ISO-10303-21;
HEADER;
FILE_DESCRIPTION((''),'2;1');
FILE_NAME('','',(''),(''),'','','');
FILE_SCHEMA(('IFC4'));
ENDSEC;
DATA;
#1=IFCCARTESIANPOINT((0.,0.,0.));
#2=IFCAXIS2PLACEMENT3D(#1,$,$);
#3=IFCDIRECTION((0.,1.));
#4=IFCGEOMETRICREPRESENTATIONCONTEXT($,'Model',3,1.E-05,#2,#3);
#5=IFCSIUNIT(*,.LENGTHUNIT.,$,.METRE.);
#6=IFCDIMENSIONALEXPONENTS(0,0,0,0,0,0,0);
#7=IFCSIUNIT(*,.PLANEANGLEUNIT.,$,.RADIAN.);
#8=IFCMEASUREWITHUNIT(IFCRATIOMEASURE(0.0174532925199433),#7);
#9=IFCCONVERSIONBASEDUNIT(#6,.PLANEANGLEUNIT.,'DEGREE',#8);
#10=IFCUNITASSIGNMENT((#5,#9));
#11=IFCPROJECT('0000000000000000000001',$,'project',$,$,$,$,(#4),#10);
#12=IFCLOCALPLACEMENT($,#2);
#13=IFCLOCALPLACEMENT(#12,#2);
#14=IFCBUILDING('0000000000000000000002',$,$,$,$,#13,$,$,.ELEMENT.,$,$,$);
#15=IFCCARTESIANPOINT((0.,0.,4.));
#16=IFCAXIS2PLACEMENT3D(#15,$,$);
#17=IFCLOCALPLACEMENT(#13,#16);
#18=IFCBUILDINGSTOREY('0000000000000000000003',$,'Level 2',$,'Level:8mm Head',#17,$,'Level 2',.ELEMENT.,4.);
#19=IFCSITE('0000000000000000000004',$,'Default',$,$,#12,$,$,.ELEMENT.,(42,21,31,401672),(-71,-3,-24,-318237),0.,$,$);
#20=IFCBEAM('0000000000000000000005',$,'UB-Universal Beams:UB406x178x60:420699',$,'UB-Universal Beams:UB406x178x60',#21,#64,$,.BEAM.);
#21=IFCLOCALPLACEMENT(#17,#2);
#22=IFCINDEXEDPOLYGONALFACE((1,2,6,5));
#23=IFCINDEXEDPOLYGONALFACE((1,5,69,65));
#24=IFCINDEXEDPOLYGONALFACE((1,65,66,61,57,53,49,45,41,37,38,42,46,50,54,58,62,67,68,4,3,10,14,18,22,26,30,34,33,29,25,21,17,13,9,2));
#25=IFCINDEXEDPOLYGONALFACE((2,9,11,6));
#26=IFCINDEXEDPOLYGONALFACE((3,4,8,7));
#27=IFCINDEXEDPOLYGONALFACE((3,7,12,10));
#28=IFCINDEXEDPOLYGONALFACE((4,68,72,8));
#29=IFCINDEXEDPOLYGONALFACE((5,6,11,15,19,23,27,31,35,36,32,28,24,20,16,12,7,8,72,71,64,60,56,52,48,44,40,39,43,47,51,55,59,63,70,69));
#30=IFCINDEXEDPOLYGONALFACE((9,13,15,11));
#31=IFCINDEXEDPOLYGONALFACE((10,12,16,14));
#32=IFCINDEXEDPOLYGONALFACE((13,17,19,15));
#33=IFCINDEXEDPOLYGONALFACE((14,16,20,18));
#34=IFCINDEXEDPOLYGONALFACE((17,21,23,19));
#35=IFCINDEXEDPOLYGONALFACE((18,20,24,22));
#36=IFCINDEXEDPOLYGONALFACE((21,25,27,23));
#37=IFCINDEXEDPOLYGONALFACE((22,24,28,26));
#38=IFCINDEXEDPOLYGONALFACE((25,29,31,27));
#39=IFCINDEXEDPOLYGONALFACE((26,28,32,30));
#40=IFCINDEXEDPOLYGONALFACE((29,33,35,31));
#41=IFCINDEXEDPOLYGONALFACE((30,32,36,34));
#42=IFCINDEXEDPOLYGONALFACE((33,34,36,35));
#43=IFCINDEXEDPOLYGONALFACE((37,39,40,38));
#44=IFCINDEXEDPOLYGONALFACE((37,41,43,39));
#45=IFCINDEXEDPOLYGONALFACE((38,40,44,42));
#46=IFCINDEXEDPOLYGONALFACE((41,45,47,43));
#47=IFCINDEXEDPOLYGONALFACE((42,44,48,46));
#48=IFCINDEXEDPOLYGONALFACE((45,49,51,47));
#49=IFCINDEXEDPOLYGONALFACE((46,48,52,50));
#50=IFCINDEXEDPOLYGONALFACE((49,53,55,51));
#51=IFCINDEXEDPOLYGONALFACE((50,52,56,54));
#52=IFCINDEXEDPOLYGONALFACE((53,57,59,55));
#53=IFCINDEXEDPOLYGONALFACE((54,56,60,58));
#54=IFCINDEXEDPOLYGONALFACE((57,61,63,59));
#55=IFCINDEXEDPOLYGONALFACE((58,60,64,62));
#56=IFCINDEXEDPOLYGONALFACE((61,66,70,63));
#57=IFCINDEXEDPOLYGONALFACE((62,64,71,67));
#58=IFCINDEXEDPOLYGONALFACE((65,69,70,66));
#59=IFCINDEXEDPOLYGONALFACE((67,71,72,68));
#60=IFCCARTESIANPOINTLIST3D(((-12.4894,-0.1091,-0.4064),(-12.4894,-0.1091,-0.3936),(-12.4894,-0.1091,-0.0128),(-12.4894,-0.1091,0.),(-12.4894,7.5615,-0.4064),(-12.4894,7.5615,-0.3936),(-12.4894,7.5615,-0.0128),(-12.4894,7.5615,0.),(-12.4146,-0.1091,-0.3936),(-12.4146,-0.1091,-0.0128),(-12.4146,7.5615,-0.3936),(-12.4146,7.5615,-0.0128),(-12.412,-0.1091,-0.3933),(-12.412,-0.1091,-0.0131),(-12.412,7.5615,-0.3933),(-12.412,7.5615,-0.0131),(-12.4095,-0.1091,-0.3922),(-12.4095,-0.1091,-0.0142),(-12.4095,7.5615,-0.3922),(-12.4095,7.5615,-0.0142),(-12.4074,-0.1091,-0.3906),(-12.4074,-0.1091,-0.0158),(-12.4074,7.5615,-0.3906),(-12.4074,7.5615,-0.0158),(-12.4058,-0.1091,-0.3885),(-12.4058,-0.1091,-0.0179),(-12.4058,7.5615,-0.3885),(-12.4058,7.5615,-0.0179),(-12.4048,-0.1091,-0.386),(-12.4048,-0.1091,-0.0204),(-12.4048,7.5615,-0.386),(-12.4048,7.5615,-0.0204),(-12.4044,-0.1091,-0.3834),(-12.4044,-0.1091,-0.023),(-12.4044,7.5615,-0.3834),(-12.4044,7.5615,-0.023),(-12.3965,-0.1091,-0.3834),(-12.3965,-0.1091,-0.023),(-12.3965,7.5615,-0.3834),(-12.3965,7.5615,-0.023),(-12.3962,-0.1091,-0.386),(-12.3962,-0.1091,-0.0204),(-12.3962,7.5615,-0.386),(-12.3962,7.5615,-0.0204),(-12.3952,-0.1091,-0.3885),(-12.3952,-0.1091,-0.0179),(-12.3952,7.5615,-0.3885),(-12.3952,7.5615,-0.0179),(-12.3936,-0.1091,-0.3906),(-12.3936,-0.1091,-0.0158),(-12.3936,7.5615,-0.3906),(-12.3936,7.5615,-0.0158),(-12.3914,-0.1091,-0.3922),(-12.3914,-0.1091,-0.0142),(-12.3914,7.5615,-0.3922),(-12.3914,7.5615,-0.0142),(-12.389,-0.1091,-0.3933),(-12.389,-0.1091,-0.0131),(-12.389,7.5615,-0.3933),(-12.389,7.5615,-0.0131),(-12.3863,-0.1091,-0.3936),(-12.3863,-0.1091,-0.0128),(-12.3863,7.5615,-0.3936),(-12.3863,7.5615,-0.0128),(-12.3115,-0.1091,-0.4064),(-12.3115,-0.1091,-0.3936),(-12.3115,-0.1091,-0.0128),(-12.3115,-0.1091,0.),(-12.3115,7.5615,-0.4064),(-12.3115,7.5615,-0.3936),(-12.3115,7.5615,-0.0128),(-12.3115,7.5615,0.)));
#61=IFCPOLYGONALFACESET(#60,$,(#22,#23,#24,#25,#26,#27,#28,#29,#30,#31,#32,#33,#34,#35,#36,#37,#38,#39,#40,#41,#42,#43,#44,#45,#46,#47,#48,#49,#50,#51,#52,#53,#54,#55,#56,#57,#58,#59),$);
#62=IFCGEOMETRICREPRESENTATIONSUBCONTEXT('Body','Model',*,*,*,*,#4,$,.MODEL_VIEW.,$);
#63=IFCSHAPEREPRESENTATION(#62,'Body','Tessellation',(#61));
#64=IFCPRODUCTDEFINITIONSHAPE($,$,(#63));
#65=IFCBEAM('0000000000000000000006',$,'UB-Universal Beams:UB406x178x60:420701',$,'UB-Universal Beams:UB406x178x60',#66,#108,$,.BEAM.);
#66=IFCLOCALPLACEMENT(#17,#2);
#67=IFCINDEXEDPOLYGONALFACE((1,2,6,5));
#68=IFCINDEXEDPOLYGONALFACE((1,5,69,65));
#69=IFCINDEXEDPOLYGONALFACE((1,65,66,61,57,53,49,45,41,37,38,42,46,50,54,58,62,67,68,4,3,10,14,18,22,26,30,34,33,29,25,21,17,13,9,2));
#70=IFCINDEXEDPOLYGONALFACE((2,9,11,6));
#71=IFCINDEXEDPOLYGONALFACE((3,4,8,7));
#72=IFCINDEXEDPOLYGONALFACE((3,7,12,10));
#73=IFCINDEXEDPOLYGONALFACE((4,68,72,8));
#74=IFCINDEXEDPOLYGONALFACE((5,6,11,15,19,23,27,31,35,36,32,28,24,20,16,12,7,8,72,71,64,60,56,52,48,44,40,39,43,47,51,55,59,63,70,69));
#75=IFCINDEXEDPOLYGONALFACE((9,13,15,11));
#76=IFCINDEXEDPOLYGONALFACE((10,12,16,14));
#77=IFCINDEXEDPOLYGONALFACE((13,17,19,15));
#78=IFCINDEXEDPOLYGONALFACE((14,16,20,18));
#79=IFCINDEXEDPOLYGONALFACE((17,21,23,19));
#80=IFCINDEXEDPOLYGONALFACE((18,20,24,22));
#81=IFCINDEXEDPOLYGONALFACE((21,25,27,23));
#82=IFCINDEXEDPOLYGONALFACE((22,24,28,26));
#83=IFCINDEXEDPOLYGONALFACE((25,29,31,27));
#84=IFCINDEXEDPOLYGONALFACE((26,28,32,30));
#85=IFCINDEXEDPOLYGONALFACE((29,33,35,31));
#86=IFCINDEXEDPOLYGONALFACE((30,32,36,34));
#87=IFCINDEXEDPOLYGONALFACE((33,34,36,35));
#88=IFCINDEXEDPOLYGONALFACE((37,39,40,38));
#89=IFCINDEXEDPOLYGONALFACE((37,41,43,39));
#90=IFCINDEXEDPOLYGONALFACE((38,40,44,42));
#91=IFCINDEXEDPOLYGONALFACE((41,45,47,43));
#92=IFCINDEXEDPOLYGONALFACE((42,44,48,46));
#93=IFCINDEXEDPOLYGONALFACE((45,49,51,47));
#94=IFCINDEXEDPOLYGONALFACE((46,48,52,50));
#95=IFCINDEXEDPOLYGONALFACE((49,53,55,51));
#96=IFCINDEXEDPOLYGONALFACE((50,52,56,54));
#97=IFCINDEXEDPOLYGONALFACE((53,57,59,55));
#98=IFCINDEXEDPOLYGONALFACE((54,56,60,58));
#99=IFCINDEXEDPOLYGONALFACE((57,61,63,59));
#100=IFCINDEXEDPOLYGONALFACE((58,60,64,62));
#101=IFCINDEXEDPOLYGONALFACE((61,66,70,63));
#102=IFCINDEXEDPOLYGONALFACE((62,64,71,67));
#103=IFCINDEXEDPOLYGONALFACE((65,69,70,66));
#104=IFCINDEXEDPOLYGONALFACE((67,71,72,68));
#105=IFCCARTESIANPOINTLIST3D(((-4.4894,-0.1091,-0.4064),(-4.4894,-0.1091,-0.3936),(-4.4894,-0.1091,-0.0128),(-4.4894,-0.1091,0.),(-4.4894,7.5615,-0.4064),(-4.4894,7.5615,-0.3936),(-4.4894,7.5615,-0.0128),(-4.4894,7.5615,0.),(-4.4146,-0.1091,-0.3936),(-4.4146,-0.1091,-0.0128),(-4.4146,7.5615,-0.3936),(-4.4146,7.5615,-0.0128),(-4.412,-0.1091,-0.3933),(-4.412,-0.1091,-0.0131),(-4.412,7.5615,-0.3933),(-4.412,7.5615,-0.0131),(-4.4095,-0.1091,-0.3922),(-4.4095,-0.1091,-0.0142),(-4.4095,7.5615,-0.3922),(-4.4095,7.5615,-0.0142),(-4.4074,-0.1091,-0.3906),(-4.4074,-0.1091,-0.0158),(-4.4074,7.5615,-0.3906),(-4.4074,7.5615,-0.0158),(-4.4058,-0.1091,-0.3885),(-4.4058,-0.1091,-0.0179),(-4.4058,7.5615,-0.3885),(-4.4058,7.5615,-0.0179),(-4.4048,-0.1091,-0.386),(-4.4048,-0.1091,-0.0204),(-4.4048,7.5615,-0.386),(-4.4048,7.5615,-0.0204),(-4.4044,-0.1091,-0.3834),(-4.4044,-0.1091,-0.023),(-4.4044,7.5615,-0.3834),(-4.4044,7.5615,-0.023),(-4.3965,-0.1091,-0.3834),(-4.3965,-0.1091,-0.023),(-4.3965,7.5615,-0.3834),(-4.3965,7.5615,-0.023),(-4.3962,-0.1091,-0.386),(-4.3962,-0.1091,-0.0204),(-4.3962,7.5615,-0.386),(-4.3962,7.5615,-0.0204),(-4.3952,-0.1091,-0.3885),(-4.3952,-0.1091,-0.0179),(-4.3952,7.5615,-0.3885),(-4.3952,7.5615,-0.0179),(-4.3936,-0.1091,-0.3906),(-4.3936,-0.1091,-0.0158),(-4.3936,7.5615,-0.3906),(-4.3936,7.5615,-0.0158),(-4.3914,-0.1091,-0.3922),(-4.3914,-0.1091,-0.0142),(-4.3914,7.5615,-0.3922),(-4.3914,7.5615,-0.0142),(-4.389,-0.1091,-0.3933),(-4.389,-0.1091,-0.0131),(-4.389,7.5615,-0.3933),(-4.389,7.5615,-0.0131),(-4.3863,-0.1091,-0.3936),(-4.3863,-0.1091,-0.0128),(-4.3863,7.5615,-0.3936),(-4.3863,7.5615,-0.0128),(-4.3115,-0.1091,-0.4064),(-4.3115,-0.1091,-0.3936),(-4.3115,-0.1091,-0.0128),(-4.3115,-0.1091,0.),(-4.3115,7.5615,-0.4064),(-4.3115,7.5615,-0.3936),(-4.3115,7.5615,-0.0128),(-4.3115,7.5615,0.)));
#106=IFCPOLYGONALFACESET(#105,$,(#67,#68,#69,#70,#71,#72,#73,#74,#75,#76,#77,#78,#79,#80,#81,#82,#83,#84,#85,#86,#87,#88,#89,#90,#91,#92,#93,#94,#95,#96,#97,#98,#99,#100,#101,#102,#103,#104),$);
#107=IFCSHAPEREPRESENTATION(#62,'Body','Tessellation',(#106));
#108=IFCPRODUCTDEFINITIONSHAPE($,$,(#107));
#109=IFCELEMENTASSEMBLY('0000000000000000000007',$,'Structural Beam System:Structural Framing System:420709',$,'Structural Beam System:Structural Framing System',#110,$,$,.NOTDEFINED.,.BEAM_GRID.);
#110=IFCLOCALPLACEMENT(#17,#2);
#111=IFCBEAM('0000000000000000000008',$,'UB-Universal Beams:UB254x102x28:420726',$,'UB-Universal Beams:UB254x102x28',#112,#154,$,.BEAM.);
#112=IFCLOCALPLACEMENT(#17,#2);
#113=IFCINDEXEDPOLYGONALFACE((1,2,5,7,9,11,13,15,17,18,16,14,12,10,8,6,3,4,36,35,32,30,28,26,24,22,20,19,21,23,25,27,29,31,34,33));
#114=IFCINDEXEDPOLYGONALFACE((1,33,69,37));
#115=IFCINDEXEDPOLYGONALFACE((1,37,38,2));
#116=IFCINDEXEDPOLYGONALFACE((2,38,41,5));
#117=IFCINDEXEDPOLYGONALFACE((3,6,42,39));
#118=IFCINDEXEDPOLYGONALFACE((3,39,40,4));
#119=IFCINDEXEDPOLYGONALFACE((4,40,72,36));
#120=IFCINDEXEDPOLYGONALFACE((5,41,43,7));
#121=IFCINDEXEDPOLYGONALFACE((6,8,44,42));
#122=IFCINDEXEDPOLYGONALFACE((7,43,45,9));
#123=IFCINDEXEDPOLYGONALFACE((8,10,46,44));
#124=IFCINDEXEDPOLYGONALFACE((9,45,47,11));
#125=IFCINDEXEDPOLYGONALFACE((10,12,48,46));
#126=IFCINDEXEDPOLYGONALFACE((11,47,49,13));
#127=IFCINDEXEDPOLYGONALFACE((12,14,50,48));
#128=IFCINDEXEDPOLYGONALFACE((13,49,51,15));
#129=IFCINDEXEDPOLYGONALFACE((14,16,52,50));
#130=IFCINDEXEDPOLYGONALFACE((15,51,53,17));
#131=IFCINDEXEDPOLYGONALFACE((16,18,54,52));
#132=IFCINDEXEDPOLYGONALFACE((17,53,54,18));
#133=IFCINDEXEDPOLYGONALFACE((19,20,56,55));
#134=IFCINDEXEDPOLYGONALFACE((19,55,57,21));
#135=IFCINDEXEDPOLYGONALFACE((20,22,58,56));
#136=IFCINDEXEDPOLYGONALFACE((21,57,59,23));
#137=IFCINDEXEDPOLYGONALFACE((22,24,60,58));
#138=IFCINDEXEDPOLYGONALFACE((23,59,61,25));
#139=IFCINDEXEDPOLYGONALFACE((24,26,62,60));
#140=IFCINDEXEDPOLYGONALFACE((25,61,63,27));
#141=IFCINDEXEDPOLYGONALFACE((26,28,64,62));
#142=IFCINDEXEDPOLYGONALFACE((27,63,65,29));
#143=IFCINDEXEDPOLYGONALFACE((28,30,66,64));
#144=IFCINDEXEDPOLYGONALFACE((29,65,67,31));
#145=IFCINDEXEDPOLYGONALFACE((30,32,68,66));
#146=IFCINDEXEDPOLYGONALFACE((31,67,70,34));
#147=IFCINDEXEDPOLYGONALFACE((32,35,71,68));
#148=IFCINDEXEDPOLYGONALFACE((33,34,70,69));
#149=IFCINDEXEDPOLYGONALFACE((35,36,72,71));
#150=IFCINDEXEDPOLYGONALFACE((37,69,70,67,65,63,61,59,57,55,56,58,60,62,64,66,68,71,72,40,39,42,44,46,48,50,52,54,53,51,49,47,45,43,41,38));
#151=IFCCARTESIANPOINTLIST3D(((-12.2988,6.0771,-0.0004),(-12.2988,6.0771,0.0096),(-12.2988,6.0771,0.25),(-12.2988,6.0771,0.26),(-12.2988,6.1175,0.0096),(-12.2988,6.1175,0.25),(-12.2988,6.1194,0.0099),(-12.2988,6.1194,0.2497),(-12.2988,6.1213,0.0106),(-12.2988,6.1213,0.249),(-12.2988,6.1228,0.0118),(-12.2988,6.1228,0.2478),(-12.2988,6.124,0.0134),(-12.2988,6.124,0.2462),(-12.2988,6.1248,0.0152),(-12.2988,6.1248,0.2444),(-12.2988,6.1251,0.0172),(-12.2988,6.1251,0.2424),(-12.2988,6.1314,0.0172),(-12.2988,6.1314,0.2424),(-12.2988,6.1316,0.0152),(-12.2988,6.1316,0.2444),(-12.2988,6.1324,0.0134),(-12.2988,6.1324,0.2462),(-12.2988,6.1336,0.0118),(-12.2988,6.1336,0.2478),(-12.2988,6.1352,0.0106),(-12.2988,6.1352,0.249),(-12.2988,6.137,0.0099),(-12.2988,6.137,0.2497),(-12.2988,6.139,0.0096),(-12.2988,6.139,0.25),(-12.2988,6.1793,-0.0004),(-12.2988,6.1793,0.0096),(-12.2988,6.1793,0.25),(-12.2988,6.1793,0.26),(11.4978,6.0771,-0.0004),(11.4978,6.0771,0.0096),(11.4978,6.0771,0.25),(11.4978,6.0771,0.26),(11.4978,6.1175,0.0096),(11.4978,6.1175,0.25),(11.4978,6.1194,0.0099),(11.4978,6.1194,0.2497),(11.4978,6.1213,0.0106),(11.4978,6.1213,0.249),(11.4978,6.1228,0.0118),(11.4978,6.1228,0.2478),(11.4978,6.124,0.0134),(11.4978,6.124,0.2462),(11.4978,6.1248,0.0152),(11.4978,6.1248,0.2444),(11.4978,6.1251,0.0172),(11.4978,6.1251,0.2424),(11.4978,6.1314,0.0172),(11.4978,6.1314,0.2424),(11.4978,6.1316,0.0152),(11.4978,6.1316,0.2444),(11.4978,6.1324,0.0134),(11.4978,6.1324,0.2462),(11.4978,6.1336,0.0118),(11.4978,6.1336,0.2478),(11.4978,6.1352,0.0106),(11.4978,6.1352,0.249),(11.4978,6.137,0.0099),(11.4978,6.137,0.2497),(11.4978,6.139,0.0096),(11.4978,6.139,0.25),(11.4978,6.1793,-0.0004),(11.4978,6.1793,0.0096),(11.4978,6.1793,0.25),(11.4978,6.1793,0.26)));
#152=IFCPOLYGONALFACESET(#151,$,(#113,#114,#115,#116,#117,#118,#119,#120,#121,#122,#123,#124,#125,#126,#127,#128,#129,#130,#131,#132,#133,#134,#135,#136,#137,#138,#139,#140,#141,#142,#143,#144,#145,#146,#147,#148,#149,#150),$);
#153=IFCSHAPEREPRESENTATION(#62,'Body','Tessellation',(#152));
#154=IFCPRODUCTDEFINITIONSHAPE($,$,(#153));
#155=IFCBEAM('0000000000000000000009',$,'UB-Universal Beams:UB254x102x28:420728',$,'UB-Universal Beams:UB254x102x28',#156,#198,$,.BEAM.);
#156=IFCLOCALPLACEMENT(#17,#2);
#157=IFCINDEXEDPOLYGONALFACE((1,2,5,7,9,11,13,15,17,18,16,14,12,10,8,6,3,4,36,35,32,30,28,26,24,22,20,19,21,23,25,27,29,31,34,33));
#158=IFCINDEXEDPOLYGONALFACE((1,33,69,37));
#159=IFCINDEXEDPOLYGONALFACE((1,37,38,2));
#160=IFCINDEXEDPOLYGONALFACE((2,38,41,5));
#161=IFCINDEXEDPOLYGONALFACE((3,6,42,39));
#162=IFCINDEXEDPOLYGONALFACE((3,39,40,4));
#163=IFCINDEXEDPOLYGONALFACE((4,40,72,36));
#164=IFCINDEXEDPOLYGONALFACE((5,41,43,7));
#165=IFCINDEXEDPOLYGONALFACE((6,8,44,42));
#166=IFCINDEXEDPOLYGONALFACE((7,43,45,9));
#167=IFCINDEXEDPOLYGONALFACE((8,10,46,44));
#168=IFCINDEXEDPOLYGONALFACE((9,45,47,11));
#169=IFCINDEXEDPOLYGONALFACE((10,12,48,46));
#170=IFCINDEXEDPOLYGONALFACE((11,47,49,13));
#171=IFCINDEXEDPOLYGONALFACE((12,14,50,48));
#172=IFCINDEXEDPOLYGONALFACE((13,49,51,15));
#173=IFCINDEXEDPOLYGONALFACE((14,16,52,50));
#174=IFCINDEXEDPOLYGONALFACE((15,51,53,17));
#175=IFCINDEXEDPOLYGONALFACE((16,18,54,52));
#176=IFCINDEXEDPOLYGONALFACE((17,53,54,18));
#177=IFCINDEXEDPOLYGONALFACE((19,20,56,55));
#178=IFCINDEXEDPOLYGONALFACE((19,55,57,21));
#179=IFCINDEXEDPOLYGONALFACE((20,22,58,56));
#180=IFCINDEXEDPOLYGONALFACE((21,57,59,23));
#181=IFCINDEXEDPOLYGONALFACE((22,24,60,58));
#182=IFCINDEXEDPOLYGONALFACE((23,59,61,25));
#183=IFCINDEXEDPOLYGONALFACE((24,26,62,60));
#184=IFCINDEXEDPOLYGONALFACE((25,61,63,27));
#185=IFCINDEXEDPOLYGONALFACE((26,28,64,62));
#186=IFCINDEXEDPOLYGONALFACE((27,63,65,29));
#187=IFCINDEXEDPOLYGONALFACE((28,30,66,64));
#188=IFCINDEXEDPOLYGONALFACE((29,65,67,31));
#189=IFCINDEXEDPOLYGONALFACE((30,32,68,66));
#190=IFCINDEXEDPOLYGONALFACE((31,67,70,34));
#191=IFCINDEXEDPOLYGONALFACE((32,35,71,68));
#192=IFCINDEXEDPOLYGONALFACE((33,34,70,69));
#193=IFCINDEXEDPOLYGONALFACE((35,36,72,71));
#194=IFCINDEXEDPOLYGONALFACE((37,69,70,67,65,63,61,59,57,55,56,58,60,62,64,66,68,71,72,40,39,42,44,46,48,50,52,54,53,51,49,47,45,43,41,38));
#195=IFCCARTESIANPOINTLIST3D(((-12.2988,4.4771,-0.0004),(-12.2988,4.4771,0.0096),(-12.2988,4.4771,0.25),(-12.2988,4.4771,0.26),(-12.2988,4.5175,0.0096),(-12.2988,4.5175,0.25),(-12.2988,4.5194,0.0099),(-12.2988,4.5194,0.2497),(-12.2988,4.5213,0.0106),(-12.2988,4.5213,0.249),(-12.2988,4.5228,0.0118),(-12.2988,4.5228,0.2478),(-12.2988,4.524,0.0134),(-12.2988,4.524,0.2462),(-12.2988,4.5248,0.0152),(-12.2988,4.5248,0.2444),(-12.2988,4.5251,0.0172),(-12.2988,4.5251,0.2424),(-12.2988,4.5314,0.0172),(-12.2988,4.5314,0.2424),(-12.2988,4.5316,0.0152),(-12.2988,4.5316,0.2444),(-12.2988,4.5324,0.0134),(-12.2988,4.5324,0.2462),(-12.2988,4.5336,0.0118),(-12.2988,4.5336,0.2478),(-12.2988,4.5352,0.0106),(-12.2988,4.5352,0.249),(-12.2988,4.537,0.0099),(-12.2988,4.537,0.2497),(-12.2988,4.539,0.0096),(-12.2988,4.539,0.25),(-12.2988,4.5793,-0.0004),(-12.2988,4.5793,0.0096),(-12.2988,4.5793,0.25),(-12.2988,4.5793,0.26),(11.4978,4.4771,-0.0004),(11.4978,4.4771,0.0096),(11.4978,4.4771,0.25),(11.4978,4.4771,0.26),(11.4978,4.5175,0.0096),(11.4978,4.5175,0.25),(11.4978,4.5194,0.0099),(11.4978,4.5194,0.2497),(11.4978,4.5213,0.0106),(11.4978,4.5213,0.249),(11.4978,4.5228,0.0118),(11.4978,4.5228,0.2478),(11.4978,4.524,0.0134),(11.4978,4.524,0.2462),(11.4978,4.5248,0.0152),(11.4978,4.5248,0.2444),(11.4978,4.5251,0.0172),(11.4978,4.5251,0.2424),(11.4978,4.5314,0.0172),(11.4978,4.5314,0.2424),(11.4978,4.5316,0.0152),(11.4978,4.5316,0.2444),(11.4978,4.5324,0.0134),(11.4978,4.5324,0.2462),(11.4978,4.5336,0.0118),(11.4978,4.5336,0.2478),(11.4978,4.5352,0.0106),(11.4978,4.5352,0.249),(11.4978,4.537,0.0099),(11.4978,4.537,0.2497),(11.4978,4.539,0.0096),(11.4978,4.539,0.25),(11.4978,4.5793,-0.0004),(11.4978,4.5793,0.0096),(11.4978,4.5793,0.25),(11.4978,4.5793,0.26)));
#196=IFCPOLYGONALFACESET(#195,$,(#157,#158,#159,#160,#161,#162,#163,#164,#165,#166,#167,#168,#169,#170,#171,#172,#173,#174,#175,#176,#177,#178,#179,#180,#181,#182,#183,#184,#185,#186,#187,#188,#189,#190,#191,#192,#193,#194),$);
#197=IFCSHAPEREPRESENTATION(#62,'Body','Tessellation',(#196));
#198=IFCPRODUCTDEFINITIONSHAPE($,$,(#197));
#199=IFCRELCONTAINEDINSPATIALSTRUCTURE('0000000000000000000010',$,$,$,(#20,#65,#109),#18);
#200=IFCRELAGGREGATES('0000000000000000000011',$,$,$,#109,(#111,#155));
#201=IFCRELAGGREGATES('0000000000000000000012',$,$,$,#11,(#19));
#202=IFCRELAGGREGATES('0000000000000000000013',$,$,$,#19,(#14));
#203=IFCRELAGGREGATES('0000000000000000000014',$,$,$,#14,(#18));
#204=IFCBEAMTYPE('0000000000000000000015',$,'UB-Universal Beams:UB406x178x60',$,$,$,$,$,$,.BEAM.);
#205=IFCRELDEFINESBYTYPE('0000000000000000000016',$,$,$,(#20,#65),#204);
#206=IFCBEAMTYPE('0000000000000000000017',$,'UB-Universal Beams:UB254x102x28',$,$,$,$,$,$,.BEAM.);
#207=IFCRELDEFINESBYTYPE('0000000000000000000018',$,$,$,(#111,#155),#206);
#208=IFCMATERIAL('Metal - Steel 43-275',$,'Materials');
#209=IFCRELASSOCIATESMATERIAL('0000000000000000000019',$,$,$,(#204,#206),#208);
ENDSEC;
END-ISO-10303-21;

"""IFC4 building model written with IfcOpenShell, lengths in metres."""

from ifc_helpers import new_model, entity, si_unit, converted_unit, direction, frame, frame_2d, origin, place, context, subcontext, project, spatial, i_section, extrude, source, transform, mapped, material, material_profile, profile_set, type_object, type_shapes, element, aggregate, save


model = new_model("IFC4")

# Units and contexts
model_context = context("Model", 3, precision=1e-05, world=origin(), true_north=direction((0.0, 1.0)))
body_context = subcontext(model_context, "Body", "Model", "MODEL_VIEW")
ifc_project = project(units=[si_unit("LENGTHUNIT", "METRE"), converted_unit("PLANEANGLEUNIT", "DEGREE", entity("IfcRatioMeasure", 0.0174532925199433), si_unit("PLANEANGLEUNIT", "RADIAN"), dimensions=[0, 0, 0, 0, 0, 0, 0])], contexts=[model_context])

# Site, building, storey
site_placement = place(None, origin())
site = spatial("IfcSite", under=ifc_project, at=site_placement, Name="Default", CompositionType="ELEMENT", RefLatitude=(42, 21, 31, 401672), RefLongitude=(-71, -3, -24, -318237), RefElevation=0.0)
building_placement = place(site_placement, origin())
building = spatial("IfcBuilding", under=site, at=building_placement, CompositionType="ELEMENT")
storey_placement = place(building_placement, frame((0.0, 0.0, 4.0)))
storey = spatial("IfcBuildingStorey", under=building, at=storey_placement, Name="Level 2", ObjectType="Level:8mm Head", LongName="Level 2", CompositionType="ELEMENT", Elevation=4.0)

# Beams
ifc_material_1 = material(Name="Metal - Steel 43-275", Category="Materials")
ifc_material_profile_1 = material_profile(ifc_material_1, i_section(OverallWidth=0.1779, OverallDepth=0.4064, WebThickness=0.0079, FlangeThickness=0.0128, FilletRadius=0.0102, at=frame_2d((0.0, 0.0), x_axis=(0.0, 1.0))), Name="UB406x178x60")
ifc_profile_set_1 = profile_set([ifc_material_profile_1], Name="UB406x178x60")
beam_type_1 = type_object("IfcBeamType", Name="UB-Universal Beams:UB406x178x60", PredefinedType="BEAM", material=ifc_profile_set_1)
shared_shape_1 = source(origin(), body_context, "Body", "SweptSolid", [
    extrude(i_section(OverallWidth=0.1779, OverallDepth=0.4064, WebThickness=0.0079, FlangeThickness=0.0128, FilletRadius=0.0102, at=frame_2d((0.0, 0.0), x_axis=(0.0, 1.0))), frame((-3.8373, 0.0, 0.0), z_axis=(1.0, 0.0, 0.0), x_axis=(0.0, 0.0, -1.0)), (0.0, 0.0, 1.0), 7.6706),
])
type_shapes(beam_type_1, [shared_shape_1])
for number, where, z_axis, x_axis, name in (
    (1, (-12.4005, 3.7282, -0.2032), (0.0, 0.0, 1.0), (0.0, 1.0, 0.0), "UB-Universal Beams:UB406x178x60:420699"),
    (2, (-4.4005, 3.7282, -0.2032), (0.0, 0.0, 1.0), (0.0, 1.0, 0.0), "UB-Universal Beams:UB406x178x60:420701"),
):
    element("IfcBeam", number, at=place(storey_placement, frame(where, z_axis=z_axis, x_axis=x_axis)), inside=storey, type_object=beam_type_1, Name=name, ObjectType="UB-Universal Beams:UB406x178x60", PredefinedType="BEAM", context=body_context, shape_type="MappedRepresentation", body=[
        mapped(shared_shape_1, transform((0.0, 0.0, 0.0), scale=1.0)),
    ])

# Element assembly, beams
assembly_placement = place(storey_placement, origin())
assembly = element("IfcElementAssembly", 3, at=assembly_placement, inside=storey, Name="Structural Beam System:Structural Framing System:420709", ObjectType="Structural Beam System:Structural Framing System", AssemblyPlace="NOTDEFINED", PredefinedType="BEAM_GRID")
ifc_material_profile_2 = material_profile(ifc_material_1, i_section(OverallWidth=0.1022, OverallDepth=0.2604, WebThickness=0.0063, FlangeThickness=0.01, FilletRadius=0.0076, at=frame_2d((0.0, 0.0), x_axis=(0.0, 1.0))), Name="UB254x102x28")
ifc_profile_set_2 = profile_set([ifc_material_profile_2], Name="UB254x102x28")
beam_type_2 = type_object("IfcBeamType", Name="UB-Universal Beams:UB254x102x28", PredefinedType="BEAM", material=ifc_profile_set_2)
shared_shape_2 = source(origin(), body_context, "Body", "SweptSolid", [
    extrude(i_section(OverallWidth=0.1022, OverallDepth=0.2604, WebThickness=0.0063, FlangeThickness=0.01, FilletRadius=0.0076, at=frame_2d((0.0, 0.0), x_axis=(0.0, 1.0))), frame((-11.8983, 0.0, 0.0), z_axis=(1.0, 0.0, 0.0), x_axis=(0.0, 0.0, -1.0)), (0.0, 0.0, 1.0), 23.7966),
])
type_shapes(beam_type_2, [shared_shape_2])
beam_1_placement = place(assembly_placement, frame((-0.4005, 6.1282, 0.1298)))
beam_1 = element("IfcBeam", 4, at=beam_1_placement, type_object=beam_type_2, Name="UB-Universal Beams:UB254x102x28:420726", ObjectType="UB-Universal Beams:UB254x102x28", PredefinedType="BEAM", context=body_context, shape_type="MappedRepresentation", body=[
    mapped(shared_shape_2, transform((0.0, 0.0, 0.0), scale=1.0)),
])
beam_2_placement = place(assembly_placement, frame((-0.4005, 4.5282, 0.1298)))
beam_2 = element("IfcBeam", 5, at=beam_2_placement, type_object=beam_type_2, Name="UB-Universal Beams:UB254x102x28:420728", ObjectType="UB-Universal Beams:UB254x102x28", PredefinedType="BEAM", context=body_context, shape_type="MappedRepresentation", body=[
    mapped(shared_shape_2, transform((0.0, 0.0, 0.0), scale=1.0)),
])
aggregate(assembly, [beam_1, beam_2])

save(model, "model.ifc")
